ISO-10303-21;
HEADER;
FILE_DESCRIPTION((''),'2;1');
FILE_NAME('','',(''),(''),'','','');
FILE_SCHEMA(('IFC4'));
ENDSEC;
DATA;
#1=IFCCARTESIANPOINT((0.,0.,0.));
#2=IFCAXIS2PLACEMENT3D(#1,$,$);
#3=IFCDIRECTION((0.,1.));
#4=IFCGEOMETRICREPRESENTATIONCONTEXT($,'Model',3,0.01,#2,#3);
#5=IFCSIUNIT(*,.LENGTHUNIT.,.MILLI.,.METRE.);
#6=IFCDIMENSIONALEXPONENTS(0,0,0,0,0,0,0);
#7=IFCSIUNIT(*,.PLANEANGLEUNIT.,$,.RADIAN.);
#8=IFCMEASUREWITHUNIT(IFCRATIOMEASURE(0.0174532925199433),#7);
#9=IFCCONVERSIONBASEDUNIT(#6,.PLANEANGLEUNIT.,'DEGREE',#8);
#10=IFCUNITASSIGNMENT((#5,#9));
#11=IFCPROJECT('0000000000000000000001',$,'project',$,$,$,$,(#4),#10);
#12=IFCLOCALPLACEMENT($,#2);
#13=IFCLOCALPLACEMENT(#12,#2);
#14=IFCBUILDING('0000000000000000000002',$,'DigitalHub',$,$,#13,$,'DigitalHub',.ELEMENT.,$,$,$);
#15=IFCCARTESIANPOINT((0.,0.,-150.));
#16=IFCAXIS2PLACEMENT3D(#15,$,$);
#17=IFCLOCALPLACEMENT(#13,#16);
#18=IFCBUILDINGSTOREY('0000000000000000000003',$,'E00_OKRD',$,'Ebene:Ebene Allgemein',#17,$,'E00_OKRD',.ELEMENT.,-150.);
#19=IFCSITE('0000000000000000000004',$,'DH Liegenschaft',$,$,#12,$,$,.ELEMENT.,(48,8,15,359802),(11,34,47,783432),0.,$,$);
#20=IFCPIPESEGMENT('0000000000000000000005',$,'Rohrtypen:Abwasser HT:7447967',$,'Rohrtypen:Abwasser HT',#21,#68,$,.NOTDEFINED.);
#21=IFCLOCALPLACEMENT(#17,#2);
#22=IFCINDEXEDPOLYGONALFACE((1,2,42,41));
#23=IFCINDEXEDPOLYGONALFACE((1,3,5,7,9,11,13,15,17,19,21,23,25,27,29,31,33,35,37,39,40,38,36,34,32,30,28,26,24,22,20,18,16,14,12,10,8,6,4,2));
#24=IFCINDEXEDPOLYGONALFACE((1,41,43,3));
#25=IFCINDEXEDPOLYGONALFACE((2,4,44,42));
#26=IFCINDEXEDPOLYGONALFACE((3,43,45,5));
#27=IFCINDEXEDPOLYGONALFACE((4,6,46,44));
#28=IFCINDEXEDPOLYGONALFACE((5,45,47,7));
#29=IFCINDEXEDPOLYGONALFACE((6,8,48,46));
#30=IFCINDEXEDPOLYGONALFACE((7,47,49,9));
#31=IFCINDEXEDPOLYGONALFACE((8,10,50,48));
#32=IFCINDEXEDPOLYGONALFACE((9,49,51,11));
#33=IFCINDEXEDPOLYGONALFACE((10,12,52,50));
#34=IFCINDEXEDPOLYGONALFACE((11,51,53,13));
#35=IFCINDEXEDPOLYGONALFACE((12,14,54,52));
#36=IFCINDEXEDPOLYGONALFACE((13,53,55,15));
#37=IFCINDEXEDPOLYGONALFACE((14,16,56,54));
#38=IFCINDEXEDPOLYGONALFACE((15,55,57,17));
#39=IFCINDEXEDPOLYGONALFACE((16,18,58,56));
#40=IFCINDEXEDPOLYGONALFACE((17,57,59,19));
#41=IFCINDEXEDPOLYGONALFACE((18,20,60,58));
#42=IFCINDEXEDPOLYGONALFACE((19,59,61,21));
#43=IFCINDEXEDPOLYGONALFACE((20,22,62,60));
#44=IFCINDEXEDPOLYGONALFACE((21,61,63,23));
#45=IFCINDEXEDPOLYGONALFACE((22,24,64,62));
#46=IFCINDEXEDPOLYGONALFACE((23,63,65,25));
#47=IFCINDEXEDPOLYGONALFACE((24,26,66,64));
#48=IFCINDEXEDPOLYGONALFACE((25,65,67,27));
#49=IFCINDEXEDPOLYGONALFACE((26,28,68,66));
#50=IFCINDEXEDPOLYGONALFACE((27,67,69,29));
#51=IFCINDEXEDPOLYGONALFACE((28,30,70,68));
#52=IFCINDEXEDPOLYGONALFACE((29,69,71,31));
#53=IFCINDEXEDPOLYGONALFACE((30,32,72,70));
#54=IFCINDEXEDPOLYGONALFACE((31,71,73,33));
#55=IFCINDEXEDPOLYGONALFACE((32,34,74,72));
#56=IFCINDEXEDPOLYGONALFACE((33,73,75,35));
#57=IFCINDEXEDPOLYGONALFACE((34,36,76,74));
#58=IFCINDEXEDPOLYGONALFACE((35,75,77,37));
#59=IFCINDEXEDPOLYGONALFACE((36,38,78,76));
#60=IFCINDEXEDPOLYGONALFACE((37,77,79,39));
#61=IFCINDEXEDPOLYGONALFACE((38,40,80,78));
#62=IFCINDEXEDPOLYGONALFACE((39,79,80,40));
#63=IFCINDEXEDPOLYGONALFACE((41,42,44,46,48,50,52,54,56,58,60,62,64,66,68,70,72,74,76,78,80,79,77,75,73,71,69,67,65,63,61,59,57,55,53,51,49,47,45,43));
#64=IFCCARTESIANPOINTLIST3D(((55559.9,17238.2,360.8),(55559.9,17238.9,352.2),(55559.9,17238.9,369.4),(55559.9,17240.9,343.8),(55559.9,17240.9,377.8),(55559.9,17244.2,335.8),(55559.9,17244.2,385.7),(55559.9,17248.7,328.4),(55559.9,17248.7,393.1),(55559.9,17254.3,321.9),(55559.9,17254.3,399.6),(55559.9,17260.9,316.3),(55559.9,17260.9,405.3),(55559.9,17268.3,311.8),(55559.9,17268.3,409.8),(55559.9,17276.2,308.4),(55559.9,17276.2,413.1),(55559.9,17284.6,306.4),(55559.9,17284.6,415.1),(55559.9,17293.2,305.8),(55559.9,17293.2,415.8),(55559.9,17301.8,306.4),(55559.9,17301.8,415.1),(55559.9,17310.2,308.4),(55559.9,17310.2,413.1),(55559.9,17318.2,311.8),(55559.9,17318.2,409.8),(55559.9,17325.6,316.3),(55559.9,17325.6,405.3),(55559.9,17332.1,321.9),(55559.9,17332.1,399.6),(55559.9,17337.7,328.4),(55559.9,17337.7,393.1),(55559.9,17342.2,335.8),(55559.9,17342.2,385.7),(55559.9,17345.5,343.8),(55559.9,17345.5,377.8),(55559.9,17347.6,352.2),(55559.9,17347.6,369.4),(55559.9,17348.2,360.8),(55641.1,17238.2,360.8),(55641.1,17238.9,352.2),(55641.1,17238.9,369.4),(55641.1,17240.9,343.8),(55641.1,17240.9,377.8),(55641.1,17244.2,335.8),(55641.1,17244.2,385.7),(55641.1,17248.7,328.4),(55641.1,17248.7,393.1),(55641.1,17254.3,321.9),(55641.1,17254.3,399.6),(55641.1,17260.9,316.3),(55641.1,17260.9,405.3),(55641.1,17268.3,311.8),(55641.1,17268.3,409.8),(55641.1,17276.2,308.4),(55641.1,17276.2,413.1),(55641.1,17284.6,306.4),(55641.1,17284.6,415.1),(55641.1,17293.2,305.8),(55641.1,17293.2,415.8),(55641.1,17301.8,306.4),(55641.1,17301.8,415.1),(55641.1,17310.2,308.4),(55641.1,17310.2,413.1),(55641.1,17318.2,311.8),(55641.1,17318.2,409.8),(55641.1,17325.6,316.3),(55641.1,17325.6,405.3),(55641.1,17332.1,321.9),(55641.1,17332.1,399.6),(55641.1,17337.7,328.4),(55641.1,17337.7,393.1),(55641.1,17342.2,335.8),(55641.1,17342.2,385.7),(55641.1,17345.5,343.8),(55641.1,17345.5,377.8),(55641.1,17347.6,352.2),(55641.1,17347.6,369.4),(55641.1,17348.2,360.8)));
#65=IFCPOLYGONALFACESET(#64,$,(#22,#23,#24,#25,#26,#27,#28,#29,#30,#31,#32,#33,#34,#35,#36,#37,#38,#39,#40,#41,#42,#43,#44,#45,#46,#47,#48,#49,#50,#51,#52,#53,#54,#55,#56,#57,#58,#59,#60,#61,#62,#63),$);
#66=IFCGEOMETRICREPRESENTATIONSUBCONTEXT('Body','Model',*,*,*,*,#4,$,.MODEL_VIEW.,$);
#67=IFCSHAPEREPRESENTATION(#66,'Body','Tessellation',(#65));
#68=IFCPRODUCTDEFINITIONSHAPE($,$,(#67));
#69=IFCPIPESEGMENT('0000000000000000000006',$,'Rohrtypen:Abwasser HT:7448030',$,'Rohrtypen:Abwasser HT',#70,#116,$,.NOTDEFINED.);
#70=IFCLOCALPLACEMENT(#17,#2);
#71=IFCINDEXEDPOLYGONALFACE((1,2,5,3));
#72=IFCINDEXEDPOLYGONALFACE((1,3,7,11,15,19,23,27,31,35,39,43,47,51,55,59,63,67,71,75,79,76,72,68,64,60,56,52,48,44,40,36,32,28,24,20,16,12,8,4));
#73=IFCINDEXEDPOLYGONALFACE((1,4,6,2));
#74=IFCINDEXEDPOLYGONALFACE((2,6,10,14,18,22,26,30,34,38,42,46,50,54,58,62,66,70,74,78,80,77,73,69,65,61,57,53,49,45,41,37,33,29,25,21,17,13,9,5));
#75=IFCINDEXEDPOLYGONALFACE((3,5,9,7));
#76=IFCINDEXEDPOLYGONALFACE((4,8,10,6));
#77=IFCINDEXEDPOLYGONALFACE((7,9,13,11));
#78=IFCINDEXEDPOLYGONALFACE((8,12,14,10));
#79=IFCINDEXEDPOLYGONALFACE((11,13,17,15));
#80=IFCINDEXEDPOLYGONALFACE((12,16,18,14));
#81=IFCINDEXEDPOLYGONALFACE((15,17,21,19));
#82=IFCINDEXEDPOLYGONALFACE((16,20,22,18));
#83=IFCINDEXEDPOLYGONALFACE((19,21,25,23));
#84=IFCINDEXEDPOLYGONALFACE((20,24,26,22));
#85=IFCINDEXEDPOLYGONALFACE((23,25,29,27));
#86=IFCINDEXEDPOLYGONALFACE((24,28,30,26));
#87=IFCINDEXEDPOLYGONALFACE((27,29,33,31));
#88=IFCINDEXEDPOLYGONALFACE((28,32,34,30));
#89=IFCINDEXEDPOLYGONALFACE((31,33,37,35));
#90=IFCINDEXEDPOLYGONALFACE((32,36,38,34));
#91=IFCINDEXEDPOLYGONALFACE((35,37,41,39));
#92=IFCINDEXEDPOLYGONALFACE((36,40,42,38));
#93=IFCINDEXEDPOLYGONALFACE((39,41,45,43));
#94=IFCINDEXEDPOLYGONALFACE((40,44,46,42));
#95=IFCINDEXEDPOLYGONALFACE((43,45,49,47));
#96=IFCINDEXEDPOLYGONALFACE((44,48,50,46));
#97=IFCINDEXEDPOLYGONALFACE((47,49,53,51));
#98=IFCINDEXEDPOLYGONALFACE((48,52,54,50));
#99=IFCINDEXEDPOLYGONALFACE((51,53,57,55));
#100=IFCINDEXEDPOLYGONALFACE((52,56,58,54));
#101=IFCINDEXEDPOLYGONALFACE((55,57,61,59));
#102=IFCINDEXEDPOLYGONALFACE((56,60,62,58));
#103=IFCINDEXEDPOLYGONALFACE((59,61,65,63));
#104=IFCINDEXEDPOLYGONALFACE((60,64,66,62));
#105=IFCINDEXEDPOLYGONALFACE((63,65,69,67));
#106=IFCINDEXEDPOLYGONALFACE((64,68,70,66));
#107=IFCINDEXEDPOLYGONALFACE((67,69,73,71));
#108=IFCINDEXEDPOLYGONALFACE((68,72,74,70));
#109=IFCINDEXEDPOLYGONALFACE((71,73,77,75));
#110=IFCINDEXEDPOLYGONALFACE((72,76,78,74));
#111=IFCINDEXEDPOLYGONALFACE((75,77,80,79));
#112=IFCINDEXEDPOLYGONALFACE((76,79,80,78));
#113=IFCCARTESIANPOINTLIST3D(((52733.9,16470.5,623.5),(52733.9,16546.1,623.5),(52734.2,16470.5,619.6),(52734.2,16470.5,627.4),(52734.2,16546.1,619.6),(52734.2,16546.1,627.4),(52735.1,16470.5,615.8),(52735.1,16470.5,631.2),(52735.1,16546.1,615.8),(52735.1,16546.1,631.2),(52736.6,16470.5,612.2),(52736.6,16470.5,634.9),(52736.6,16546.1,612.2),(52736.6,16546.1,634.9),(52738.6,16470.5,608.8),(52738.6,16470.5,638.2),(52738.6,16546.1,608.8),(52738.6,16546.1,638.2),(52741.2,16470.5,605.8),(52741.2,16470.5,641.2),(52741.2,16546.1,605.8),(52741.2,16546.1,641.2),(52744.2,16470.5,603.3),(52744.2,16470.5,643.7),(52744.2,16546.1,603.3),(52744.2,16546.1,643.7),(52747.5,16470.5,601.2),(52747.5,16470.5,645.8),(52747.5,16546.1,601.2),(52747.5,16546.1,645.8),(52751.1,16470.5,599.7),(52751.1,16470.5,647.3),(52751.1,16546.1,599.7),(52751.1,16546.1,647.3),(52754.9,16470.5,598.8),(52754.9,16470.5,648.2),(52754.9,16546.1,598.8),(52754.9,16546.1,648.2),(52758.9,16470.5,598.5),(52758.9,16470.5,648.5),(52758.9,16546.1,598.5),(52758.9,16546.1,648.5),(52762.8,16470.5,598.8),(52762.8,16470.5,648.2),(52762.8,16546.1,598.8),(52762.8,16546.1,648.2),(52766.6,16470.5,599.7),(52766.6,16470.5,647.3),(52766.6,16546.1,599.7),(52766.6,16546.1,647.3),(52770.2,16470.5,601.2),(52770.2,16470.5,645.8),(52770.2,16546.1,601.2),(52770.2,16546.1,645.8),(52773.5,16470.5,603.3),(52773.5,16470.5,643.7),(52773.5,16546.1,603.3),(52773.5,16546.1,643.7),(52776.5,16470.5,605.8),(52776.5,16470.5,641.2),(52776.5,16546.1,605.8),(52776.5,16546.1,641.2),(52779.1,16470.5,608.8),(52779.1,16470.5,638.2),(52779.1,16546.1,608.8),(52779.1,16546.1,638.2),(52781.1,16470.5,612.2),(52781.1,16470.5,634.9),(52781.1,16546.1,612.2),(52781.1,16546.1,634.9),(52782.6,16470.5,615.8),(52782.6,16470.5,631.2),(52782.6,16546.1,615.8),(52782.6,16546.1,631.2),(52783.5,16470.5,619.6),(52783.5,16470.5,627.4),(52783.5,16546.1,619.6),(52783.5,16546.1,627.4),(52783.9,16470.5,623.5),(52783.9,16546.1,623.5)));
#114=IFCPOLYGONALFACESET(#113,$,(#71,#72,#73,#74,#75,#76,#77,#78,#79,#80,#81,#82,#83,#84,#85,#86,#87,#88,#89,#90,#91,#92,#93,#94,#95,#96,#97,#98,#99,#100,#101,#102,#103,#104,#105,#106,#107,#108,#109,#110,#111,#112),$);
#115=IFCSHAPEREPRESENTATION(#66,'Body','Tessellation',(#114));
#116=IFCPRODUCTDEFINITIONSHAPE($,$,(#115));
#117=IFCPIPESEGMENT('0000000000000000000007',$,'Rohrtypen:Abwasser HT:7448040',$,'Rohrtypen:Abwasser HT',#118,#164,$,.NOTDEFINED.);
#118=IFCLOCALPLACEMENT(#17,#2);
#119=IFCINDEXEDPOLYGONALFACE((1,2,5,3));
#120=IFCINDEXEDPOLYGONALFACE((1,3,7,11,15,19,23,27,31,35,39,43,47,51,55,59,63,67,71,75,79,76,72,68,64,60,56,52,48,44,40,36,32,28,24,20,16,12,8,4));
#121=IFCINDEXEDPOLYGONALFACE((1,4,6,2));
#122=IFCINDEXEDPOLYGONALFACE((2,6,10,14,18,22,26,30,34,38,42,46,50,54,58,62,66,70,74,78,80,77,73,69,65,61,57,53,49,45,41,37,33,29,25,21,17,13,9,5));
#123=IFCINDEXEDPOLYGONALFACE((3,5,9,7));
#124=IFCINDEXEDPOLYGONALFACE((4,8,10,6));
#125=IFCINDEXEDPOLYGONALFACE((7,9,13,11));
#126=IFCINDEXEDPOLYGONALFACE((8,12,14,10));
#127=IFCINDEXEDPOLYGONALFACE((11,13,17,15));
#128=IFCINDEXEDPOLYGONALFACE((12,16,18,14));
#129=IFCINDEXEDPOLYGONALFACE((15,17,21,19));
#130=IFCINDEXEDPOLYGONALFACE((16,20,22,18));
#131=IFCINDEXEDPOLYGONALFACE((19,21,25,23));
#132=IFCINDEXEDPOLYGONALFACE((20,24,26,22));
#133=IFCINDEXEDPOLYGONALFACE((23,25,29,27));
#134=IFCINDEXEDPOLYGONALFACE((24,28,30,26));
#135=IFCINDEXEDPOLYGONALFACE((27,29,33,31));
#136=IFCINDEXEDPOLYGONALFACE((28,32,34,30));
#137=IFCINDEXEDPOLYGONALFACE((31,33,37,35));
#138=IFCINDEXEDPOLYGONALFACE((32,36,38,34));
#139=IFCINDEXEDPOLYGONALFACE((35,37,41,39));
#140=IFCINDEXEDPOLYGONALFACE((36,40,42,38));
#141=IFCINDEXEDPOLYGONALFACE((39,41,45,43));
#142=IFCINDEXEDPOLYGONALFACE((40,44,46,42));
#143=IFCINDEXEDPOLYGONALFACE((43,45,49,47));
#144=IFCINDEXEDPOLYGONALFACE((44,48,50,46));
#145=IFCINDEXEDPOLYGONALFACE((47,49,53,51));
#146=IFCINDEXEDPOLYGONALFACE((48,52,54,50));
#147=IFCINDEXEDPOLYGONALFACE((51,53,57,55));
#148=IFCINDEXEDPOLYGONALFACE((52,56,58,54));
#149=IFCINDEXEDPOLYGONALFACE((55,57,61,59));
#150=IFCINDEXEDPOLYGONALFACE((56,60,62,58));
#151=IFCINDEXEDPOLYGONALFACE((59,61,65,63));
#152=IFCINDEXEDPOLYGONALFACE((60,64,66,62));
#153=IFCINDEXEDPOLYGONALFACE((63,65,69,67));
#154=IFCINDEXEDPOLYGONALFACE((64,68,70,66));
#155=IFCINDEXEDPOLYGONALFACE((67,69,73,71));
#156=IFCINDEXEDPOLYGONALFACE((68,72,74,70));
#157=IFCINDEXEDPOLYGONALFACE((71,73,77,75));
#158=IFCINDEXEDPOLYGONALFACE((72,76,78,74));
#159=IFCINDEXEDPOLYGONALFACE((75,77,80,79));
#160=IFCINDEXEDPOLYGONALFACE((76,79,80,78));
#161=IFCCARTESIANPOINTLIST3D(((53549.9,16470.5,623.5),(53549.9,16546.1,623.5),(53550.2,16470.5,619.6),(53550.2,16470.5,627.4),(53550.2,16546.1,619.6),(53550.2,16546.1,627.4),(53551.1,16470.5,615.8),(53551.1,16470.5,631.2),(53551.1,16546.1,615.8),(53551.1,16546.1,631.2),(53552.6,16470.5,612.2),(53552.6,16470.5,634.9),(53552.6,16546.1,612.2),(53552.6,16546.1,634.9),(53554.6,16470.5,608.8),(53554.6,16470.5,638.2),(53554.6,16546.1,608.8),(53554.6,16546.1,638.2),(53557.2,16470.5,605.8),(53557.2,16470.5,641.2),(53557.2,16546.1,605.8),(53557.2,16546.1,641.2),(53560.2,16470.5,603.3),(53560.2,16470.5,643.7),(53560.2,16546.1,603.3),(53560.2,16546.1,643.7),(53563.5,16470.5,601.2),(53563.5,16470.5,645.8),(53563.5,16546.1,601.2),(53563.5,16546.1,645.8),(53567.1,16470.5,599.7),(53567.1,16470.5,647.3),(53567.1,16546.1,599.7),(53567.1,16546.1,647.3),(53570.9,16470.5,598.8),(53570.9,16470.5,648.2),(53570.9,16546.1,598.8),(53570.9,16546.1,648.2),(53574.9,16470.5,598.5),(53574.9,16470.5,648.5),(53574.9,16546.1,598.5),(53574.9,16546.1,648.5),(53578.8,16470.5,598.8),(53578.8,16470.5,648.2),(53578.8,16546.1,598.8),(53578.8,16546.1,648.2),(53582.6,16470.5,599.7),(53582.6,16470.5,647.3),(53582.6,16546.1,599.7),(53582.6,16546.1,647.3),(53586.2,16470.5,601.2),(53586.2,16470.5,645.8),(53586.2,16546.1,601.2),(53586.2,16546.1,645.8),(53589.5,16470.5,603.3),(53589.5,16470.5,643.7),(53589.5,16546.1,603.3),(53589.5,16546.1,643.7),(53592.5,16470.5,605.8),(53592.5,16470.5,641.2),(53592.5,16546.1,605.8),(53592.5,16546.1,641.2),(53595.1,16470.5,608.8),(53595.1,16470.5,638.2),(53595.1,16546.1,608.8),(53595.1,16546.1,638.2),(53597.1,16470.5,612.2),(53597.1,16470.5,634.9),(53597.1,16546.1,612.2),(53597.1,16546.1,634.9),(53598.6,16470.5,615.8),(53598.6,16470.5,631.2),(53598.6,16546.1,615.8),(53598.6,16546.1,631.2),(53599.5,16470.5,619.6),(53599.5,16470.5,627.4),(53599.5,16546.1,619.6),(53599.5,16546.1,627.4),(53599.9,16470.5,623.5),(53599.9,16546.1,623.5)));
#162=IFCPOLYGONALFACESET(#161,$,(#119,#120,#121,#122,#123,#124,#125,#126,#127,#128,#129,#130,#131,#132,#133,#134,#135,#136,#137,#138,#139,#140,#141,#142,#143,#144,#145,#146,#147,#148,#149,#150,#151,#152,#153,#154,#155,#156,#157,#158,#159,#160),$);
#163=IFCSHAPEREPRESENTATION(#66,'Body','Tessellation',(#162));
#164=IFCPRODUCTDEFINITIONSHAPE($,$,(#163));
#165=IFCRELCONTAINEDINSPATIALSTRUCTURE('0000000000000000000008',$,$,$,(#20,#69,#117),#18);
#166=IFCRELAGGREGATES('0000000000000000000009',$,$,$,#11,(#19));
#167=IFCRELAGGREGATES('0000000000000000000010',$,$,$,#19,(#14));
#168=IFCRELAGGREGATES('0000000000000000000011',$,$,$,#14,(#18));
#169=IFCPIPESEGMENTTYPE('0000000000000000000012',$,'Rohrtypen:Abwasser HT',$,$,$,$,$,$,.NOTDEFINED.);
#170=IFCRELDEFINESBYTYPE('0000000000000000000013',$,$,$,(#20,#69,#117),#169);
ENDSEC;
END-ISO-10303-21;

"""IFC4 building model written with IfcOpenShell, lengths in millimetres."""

from ifc_helpers import new_model, entity, si_unit, converted_unit, direction, frame, origin, place, context, subcontext, project, spatial, indexed_curve, outline, extrude, type_object, element, save


model = new_model("IFC4")

# Units and contexts
model_context = context("Model", 3, precision=0.01, world=origin(), true_north=direction((0.0, 1.0)))
body_context = subcontext(model_context, "Body", "Model", "MODEL_VIEW")
ifc_project = project(units=[si_unit("LENGTHUNIT", "METRE", prefix="MILLI"), converted_unit("PLANEANGLEUNIT", "DEGREE", entity("IfcRatioMeasure", 0.0174532925199433), si_unit("PLANEANGLEUNIT", "RADIAN"), dimensions=[0, 0, 0, 0, 0, 0, 0])], contexts=[model_context])

# Site, building, storey
site_placement = place(None, origin())
site = spatial("IfcSite", under=ifc_project, at=site_placement, Name="DH Liegenschaft", CompositionType="ELEMENT", RefLatitude=(48, 8, 15, 359802), RefLongitude=(11, 34, 47, 783432), RefElevation=0.0)
building_placement = place(site_placement, origin())
building = spatial("IfcBuilding", under=site, at=building_placement, Name="DigitalHub", LongName="DigitalHub", CompositionType="ELEMENT")
storey_placement = place(building_placement, frame((0.0, 0.0, -150.0)))
storey = spatial("IfcBuildingStorey", under=building, at=storey_placement, Name="E00_OKRD", ObjectType="Ebene:Ebene Allgemein", LongName="E00_OKRD", CompositionType="ELEMENT", Elevation=-150.0)

# Pipe segments
pipe_segment_type_1 = type_object("IfcPipeSegmentType", Name="Rohrtypen:Abwasser HT", PredefinedType="NOTDEFINED")
pipe_segment_1_placement = place(storey_placement, frame((55559.9, 17236.6, 304.2)))
element("IfcPipeSegment", 1, at=pipe_segment_1_placement, inside=storey, type_object=pipe_segment_type_1, Name="Rohrtypen:Abwasser HT:7447967", ObjectType="Rohrtypen:Abwasser HT", PredefinedType="NOTDEFINED", context=body_context, shape_type="SweptSolid", body=[
    extrude(outline(indexed_curve([(55.0, 0.0), (54.3, 8.6), (52.3, 17.0), (49.0, 25.0), (44.5, 32.3), (38.9, 38.9), (32.3, 44.5), (25.0, 49.0), (17.0, 52.3), (8.6, 54.3), (0.0, 55.0), (-8.6, 54.3), (-17.0, 52.3), (-25.0, 49.0), (-32.3, 44.5), (-38.9, 38.9), (-44.5, 32.3), (-49.0, 25.0), (-52.3, 17.0), (-54.3, 8.6), (-55.0, 0.0), (-54.3, -8.6), (-52.3, -17.0), (-49.0, -25.0), (-44.5, -32.3), (-38.9, -38.9), (-32.3, -44.5), (-25.0, -49.0), (-17.0, -52.3), (-8.6, -54.3), (0.0, -55.0), (8.6, -54.3), (17.0, -52.3), (25.0, -49.0), (32.3, -44.5), (38.9, -38.9), (44.5, -32.3), (49.0, -25.0), (52.3, -17.0), (54.3, -8.6), (55.0, 0.0)], self_intersect=False)), frame((0.0, 56.6, 56.6), z_axis=(1.0, 0.0, 0.0), x_axis=(0.0, -1.0, 0.0)), (0.0, 0.0, 1.0), 81.3),
])
pipe_segment_2_placement = place(storey_placement, frame((52732.3, 16470.5, 596.9)))
element("IfcPipeSegment", 2, at=pipe_segment_2_placement, inside=storey, type_object=pipe_segment_type_1, Name="Rohrtypen:Abwasser HT:7448030", ObjectType="Rohrtypen:Abwasser HT", PredefinedType="NOTDEFINED", context=body_context, shape_type="SweptSolid", body=[
    extrude(outline(indexed_curve([(25.0, 0.0), (24.7, 3.9), (23.8, 7.7), (22.3, 11.3), (20.2, 14.7), (17.7, 17.7), (14.7, 20.2), (11.3, 22.3), (7.7, 23.8), (3.9, 24.7), (0.0, 25.0), (-3.9, 24.7), (-7.7, 23.8), (-11.3, 22.3), (-14.7, 20.2), (-17.7, 17.7), (-20.2, 14.7), (-22.3, 11.3), (-23.8, 7.7), (-24.7, 3.9), (-25.0, 0.0), (-24.7, -3.9), (-23.8, -7.7), (-22.3, -11.3), (-20.2, -14.7), (-17.7, -17.7), (-14.7, -20.2), (-11.3, -22.3), (-7.7, -23.8), (-3.9, -24.7), (0.0, -25.0), (3.9, -24.7), (7.7, -23.8), (11.3, -22.3), (14.7, -20.2), (17.7, -17.7), (20.2, -14.7), (22.3, -11.3), (23.8, -7.7), (24.7, -3.9), (25.0, 0.0)], self_intersect=False)), frame((26.6, 0.0, 26.6), z_axis=(0.0, 1.0, 0.0), x_axis=(1.0, 0.0, 0.0)), (0.0, 0.0, 1.0), 75.6),
])
pipe_segment_3_placement = place(storey_placement, frame((53548.3, 16470.5, 596.9)))
element("IfcPipeSegment", 3, at=pipe_segment_3_placement, inside=storey, type_object=pipe_segment_type_1, Name="Rohrtypen:Abwasser HT:7448040", ObjectType="Rohrtypen:Abwasser HT", PredefinedType="NOTDEFINED", context=body_context, shape_type="SweptSolid", body=[
    extrude(outline(indexed_curve([(25.0, 0.0), (24.7, 3.9), (23.8, 7.7), (22.3, 11.3), (20.2, 14.7), (17.7, 17.7), (14.7, 20.2), (11.3, 22.3), (7.7, 23.8), (3.9, 24.7), (0.0, 25.0), (-3.9, 24.7), (-7.7, 23.8), (-11.3, 22.3), (-14.7, 20.2), (-17.7, 17.7), (-20.2, 14.7), (-22.3, 11.3), (-23.8, 7.7), (-24.7, 3.9), (-25.0, 0.0), (-24.7, -3.9), (-23.8, -7.7), (-22.3, -11.3), (-20.2, -14.7), (-17.7, -17.7), (-14.7, -20.2), (-11.3, -22.3), (-7.7, -23.8), (-3.9, -24.7), (0.0, -25.0), (3.9, -24.7), (7.7, -23.8), (11.3, -22.3), (14.7, -20.2), (17.7, -17.7), (20.2, -14.7), (22.3, -11.3), (23.8, -7.7), (24.7, -3.9), (25.0, 0.0)], self_intersect=False)), frame((26.6, 0.0, 26.6), z_axis=(0.0, 1.0, 0.0), x_axis=(1.0, 0.0, 0.0)), (0.0, 0.0, 1.0), 75.6),
])

save(model, "model.ifc")
